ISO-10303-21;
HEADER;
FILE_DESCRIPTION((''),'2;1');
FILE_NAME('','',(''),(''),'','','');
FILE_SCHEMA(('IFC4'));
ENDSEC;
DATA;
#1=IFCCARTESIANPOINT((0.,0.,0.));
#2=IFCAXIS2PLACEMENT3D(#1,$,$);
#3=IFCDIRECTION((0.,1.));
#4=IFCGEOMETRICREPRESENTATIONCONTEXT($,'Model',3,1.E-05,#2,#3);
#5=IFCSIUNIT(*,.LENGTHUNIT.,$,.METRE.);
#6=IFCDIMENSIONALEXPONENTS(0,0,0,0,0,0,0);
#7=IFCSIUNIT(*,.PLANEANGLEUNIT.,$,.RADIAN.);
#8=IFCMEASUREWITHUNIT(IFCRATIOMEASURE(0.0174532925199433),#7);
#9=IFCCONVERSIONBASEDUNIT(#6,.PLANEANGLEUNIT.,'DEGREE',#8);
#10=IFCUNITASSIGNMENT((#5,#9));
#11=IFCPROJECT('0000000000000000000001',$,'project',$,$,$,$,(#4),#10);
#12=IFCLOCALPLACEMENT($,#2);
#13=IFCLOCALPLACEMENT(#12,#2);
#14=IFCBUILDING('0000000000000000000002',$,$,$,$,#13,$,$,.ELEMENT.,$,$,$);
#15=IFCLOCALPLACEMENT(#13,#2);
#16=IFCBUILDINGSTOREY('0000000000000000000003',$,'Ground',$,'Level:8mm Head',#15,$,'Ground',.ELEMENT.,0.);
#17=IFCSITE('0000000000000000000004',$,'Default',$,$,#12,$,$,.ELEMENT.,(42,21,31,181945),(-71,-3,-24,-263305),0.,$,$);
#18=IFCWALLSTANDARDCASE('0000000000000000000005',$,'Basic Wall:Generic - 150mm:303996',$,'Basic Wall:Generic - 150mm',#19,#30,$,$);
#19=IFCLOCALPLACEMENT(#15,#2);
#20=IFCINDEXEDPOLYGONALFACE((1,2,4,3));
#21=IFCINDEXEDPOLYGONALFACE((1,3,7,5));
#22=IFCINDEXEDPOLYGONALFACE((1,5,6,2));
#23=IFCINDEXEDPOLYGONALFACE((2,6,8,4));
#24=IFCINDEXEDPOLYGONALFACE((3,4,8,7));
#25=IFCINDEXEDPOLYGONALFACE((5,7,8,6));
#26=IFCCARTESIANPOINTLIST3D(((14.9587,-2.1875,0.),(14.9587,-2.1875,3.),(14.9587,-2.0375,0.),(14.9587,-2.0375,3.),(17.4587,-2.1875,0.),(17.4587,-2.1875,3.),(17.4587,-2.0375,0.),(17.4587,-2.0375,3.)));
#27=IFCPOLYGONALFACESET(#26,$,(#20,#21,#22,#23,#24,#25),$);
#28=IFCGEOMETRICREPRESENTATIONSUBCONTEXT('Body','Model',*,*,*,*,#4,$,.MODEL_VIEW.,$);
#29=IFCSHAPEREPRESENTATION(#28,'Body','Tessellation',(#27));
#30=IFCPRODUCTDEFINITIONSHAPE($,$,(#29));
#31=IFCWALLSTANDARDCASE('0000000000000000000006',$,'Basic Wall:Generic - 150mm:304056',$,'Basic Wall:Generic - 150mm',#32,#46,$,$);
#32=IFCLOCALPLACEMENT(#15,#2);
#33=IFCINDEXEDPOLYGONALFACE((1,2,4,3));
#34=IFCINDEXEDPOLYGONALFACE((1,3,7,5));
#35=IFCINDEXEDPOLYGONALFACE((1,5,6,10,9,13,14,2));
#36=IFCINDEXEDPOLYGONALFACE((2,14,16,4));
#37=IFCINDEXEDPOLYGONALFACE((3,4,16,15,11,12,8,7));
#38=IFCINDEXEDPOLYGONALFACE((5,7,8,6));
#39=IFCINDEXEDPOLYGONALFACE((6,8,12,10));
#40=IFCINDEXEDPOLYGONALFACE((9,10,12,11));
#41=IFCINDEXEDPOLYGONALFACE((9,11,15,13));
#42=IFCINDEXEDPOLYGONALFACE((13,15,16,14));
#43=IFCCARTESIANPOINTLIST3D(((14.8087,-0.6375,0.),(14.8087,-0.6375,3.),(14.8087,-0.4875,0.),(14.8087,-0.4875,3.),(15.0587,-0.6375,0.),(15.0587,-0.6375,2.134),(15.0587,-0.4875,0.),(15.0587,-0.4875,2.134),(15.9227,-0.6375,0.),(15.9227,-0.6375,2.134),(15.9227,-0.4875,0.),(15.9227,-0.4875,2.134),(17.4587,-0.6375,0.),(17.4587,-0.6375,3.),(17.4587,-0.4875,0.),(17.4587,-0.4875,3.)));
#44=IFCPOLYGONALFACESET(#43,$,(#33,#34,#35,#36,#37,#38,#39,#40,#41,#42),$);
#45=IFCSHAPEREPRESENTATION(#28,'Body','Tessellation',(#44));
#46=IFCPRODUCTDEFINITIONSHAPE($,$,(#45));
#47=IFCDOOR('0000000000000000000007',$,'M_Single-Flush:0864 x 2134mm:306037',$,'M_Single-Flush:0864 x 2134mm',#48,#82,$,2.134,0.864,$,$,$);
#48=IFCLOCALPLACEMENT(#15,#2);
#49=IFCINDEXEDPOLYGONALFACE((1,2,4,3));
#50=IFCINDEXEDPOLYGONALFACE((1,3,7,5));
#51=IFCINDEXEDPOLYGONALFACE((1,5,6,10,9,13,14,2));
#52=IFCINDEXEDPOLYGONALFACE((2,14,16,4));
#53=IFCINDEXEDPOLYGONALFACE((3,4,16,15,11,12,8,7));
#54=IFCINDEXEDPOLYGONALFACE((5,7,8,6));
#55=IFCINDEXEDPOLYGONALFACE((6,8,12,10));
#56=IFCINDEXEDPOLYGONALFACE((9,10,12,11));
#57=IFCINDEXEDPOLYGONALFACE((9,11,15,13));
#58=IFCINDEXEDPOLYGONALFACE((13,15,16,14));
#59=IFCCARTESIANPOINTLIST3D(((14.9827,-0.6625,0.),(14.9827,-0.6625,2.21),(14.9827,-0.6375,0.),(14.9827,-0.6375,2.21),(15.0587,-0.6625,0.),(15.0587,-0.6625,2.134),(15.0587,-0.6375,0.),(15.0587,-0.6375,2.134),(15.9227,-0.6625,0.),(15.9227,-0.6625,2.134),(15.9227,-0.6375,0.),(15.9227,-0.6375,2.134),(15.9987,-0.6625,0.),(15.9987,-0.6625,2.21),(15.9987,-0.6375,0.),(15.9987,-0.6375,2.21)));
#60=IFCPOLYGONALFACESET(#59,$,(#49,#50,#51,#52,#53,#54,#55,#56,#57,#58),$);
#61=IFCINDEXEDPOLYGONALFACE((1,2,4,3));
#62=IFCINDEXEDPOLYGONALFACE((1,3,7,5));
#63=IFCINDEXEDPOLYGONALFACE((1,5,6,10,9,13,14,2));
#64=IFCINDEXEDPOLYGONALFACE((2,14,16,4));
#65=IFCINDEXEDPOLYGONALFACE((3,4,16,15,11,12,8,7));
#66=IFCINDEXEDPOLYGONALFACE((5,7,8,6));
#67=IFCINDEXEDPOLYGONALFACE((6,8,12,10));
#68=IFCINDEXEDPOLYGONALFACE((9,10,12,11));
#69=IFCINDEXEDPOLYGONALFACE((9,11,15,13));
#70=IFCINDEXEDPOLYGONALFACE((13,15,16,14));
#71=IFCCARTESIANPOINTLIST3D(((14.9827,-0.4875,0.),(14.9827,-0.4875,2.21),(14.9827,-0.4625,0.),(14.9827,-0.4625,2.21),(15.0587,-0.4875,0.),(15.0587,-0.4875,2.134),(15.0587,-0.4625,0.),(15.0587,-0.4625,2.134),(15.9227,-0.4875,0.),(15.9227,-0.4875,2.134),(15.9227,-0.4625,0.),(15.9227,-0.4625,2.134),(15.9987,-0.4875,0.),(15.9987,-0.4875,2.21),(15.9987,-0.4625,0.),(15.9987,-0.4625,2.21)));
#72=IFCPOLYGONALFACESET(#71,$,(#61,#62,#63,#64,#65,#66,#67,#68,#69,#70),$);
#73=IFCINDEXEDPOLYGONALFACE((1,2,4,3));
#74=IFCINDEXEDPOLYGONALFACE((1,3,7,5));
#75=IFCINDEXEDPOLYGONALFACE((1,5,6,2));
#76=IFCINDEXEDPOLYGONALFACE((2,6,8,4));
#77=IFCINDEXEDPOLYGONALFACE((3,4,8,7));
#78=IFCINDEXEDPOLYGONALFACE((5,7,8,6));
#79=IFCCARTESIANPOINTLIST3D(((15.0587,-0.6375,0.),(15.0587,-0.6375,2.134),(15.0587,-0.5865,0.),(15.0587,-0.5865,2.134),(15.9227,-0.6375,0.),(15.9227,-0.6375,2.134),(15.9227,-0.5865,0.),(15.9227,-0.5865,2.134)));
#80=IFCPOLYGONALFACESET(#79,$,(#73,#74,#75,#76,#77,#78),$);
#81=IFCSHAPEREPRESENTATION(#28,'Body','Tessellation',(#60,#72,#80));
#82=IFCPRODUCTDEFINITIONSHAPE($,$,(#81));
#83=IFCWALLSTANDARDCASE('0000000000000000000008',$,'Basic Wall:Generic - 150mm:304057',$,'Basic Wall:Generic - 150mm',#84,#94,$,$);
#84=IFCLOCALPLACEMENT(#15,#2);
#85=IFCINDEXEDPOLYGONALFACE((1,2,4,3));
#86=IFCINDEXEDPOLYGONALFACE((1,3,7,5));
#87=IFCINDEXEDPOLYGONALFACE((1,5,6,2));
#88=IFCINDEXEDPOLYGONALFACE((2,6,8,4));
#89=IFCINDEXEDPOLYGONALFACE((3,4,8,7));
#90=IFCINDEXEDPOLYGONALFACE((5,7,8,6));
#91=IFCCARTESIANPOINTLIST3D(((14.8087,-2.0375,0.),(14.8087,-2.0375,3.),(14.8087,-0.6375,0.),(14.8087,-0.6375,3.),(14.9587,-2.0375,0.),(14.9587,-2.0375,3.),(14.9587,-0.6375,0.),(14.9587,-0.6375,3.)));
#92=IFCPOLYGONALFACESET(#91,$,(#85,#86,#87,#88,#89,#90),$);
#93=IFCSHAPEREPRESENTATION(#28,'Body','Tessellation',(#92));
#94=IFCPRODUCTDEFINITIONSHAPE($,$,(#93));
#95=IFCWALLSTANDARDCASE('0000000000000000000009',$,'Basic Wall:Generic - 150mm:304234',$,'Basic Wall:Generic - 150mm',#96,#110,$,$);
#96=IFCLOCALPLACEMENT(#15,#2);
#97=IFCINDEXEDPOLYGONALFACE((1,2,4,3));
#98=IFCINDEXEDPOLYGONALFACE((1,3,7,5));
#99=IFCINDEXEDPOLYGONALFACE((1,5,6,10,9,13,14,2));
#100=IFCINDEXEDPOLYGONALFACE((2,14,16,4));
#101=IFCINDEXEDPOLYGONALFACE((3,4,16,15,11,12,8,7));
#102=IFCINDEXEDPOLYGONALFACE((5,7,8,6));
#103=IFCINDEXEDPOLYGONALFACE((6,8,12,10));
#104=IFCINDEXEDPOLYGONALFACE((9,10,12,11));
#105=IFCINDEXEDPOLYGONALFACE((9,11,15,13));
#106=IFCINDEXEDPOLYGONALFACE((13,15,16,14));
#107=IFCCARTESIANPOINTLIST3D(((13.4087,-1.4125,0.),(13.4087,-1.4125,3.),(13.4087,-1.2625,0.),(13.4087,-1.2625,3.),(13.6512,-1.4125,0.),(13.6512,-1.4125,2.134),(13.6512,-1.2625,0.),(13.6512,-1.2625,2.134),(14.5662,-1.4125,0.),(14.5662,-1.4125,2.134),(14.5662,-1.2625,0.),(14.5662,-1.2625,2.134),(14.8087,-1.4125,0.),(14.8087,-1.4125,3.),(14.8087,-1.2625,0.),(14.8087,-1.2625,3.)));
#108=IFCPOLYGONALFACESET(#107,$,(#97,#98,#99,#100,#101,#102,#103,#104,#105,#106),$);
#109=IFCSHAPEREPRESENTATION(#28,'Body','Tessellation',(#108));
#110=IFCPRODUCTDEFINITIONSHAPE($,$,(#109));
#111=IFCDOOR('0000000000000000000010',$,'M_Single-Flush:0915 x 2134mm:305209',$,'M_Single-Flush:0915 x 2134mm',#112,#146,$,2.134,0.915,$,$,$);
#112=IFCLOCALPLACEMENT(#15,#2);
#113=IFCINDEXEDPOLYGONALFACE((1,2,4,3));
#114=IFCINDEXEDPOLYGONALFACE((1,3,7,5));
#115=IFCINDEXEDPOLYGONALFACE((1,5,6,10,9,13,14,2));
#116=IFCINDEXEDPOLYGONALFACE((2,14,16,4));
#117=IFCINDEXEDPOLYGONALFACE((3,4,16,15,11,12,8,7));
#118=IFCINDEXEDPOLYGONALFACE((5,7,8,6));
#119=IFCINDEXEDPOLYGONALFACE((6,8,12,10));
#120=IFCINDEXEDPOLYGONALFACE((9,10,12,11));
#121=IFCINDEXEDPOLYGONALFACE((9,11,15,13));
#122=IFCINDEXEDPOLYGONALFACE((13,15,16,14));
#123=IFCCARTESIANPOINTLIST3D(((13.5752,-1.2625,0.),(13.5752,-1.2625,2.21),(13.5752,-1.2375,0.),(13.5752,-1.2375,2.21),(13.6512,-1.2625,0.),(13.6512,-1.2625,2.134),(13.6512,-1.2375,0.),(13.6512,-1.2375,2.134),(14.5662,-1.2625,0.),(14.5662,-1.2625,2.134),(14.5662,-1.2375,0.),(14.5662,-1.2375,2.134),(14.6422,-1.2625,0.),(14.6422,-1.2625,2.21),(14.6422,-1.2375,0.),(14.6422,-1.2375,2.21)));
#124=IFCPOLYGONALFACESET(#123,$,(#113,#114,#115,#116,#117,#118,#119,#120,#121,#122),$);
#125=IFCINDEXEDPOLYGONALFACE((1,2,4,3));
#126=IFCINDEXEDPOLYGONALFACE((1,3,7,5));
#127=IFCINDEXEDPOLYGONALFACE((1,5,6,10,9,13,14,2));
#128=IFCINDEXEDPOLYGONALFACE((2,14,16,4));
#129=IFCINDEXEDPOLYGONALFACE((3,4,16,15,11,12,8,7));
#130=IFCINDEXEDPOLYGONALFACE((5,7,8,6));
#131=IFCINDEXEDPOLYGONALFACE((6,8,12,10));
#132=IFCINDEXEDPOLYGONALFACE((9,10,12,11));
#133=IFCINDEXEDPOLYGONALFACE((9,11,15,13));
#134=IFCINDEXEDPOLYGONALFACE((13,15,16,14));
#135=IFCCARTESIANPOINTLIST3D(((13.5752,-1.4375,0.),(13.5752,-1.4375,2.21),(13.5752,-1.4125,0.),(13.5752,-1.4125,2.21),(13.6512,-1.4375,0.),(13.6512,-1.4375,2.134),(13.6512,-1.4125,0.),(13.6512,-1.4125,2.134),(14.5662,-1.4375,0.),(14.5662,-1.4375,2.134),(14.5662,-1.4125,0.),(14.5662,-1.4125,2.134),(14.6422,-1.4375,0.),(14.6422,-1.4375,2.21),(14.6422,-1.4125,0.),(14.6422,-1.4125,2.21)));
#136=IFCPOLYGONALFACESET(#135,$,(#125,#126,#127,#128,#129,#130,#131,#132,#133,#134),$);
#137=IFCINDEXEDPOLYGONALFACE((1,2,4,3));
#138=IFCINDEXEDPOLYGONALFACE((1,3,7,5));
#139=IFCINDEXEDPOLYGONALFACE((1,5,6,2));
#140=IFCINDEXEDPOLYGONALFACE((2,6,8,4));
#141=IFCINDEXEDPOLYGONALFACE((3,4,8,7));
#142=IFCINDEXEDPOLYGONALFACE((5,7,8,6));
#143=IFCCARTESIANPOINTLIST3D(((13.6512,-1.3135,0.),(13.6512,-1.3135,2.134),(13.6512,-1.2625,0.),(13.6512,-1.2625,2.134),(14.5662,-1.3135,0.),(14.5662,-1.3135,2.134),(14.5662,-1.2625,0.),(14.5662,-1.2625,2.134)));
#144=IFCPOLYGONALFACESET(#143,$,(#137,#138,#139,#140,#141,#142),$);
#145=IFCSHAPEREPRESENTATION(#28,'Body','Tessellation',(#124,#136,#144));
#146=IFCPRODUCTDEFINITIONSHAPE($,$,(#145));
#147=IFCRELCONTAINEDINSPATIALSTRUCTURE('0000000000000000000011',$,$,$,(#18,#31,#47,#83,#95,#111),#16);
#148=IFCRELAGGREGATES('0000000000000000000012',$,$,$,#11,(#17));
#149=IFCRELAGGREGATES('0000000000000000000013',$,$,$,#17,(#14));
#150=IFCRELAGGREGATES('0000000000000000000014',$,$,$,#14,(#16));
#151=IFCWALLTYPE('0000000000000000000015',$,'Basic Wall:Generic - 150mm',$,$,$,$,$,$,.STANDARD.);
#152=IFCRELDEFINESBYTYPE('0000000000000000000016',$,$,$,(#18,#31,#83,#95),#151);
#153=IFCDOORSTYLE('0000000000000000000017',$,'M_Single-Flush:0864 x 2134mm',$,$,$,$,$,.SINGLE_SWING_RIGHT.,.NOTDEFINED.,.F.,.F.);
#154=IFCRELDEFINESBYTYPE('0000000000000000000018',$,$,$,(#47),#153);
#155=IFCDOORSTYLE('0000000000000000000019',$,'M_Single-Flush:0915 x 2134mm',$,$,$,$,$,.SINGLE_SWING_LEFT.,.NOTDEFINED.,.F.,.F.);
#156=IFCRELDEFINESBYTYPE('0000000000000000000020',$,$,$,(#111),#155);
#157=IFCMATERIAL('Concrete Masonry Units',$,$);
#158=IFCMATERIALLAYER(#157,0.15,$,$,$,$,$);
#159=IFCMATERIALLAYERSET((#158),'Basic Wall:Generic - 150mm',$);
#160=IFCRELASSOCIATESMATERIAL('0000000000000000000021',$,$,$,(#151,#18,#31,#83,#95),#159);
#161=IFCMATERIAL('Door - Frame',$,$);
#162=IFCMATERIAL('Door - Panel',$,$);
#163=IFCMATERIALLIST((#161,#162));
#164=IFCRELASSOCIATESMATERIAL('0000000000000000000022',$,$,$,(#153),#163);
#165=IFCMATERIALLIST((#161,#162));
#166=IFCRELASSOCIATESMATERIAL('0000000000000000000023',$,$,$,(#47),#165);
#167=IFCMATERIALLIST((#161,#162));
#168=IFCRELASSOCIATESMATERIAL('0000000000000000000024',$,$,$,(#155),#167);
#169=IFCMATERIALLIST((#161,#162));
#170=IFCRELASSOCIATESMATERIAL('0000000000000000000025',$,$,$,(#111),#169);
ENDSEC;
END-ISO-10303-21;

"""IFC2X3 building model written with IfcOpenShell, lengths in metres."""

from ifc_helpers import new_model, entity, si_unit, converted_unit, direction, frame, frame_2d, origin, place, context, subcontext, project, spatial, polyline, rectangle, outline, extrude, source, transform, mapped, material, material_list, layer, layer_set, layer_usage, type_object, type_shapes, element, fill, save


model = new_model("IFC2X3")

# Units and contexts
model_context = context("Model", 3, precision=1e-05, world=origin(), true_north=direction((0.0, 1.0)))
body_context = subcontext(model_context, "Body", "Model", "MODEL_VIEW")
ifc_project = project(units=[si_unit("LENGTHUNIT", "METRE"), converted_unit("PLANEANGLEUNIT", "DEGREE", entity("IfcRatioMeasure", 0.0174532925199433), si_unit("PLANEANGLEUNIT", "RADIAN"), dimensions=[0, 0, 0, 0, 0, 0, 0])], contexts=[model_context])

# Site, building, storey
site_placement = place(None, origin())
site = spatial("IfcSite", under=ifc_project, at=site_placement, Name="Default", CompositionType="ELEMENT", RefLatitude=(42, 21, 31, 181945), RefLongitude=(-71, -3, -24, -263305), RefElevation=0.0)
building_placement = place(site_placement, origin())
building = spatial("IfcBuilding", under=site, at=building_placement, CompositionType="ELEMENT")
storey_placement = place(building_placement, origin())
storey = spatial("IfcBuildingStorey", under=building, at=storey_placement, Name="Ground", ObjectType="Level:8mm Head", LongName="Ground", CompositionType="ELEMENT", Elevation=0.0)

# Wall
ifc_material_1 = material(Name="Concrete Masonry Units")
ifc_layer = layer(ifc_material_1, 0.15)
ifc_layer_set = layer_set([ifc_layer], Name="Basic Wall:Generic - 150mm")
ifc_layer_usage_1 = layer_usage(ifc_layer_set, "AXIS2", "POSITIVE", -0.075)
wall_type = type_object("IfcWallType", Name="Basic Wall:Generic - 150mm", PredefinedType="STANDARD", material=ifc_layer_set)
wall_1_placement = place(storey_placement, frame((14.9587, -2.1125, 0.0)))
element("IfcWallStandardCase", 1, at=wall_1_placement, inside=storey, type_object=wall_type, material=ifc_layer_usage_1, Name="Basic Wall:Generic - 150mm:303996", ObjectType="Basic Wall:Generic - 150mm", context=body_context, shape_type="SweptSolid", body=[
    extrude(rectangle(XDim=2.5, YDim=0.15, at=frame_2d((1.25, 0.0), x_axis=(-1.0, 0.0))), origin(), (0.0, 0.0, 1.0), 3.0),
])

# Wall, opening, door
ifc_layer_usage_2 = layer_usage(ifc_layer_set, "AXIS2", "POSITIVE", -0.075)
wall_2_placement = place(storey_placement, frame((17.4587, -0.5625, 0.0), z_axis=(0.0, 0.0, 1.0), x_axis=(-1.0, 0.0, 0.0)))
wall_2 = element("IfcWallStandardCase", 2, at=wall_2_placement, inside=storey, type_object=wall_type, material=ifc_layer_usage_2, Name="Basic Wall:Generic - 150mm:304056", ObjectType="Basic Wall:Generic - 150mm", context=body_context, shape_type="SweptSolid", body=[
    extrude(rectangle(XDim=2.65, YDim=0.15, at=frame_2d((1.325, 0.0), x_axis=(-1.0, 0.0))), origin(), (0.0, 0.0, 1.0), 3.0),
])
opening_1_placement = place(wall_2_placement, frame((1.536, -0.075, 0.0)))
opening_1 = element("IfcOpeningElement", 3, at=opening_1_placement, cuts=wall_2, ObjectType="Opening", context=body_context, shape_type="SweptSolid", body=[
    extrude(rectangle(XDim=0.864, YDim=2.134, at=frame_2d((1.067, 0.432), x_axis=(0.0, 1.0))), frame((0.0, 0.0, 0.0), z_axis=(0.0, 1.0, 0.0), x_axis=(0.0, 0.0, 1.0)), (0.0, 0.0, 1.0), 0.15),
])
ifc_material_2 = material(Name="Door - Frame")
ifc_material_3 = material(Name="Door - Panel")
ifc_material_list_1 = material_list([ifc_material_2, ifc_material_3])
ifc_material_list_2 = material_list([ifc_material_2, ifc_material_3])
door_style_1 = type_object("IfcDoorStyle", Name="M_Single-Flush:0864 x 2134mm", ConstructionType="NOTDEFINED", OperationType="SINGLE_SWING_RIGHT", ParameterTakesPrecedence=False, Sizeable=False, material=ifc_material_list_2)
shared_shape_1 = source(origin(), body_context, "Body", "SweptSolid", [
    extrude(outline(polyline([(-0.508, -1.124), (0.508, -1.124), (0.508, 1.086), (0.432, 1.086), (0.432, -1.048), (-0.432, -1.048), (-0.432, 1.086), (-0.508, 1.086), (-0.508, -1.124)])), frame((0.432, 0.15, 1.086), z_axis=(0.0, 1.0, 0.0), x_axis=(1.0, 0.0, 0.0)), (0.0, 0.0, 1.0), 0.025),
    extrude(outline(polyline([(-1.124, -0.508), (1.086, -0.508), (1.086, -0.432), (-1.048, -0.432), (-1.048, 0.432), (1.086, 0.432), (1.086, 0.508), (-1.124, 0.508), (-1.124, -0.508)])), frame((0.432, -0.025, 1.086), z_axis=(0.0, 1.0, 0.0), x_axis=(0.0, 0.0, -1.0)), (0.0, 0.0, 1.0), 0.025),
    extrude(rectangle(XDim=0.051, YDim=0.864, at=frame_2d((0.0, 0.0), x_axis=(1.0, 0.0))), frame((0.432, 0.1245, 0.0), z_axis=(0.0, 0.0, 1.0), x_axis=(0.0, 1.0, 0.0)), (0.0, 0.0, 1.0), 2.134),
])
type_shapes(door_style_1, [shared_shape_1])
door_1_placement = place(opening_1_placement, origin())
door_1 = element("IfcDoor", 4, at=door_1_placement, inside=storey, type_object=door_style_1, material=ifc_material_list_1, Name="M_Single-Flush:0864 x 2134mm:306037", ObjectType="M_Single-Flush:0864 x 2134mm", OverallHeight=2.134, OverallWidth=0.864, context=body_context, shape_type="MappedRepresentation", body=[
    mapped(shared_shape_1, transform((0.0, 0.0, 0.0), scale=1.0)),
])
fill(opening_1, door_1)

# Wall
ifc_layer_usage_3 = layer_usage(ifc_layer_set, "AXIS2", "NEGATIVE", 0.075)
wall_3_placement = place(storey_placement, frame((14.8837, -0.6375, 0.0), z_axis=(0.0, 0.0, 1.0), x_axis=(0.0, -1.0, 0.0)))
element("IfcWallStandardCase", 5, at=wall_3_placement, inside=storey, type_object=wall_type, material=ifc_layer_usage_3, Name="Basic Wall:Generic - 150mm:304057", ObjectType="Basic Wall:Generic - 150mm", context=body_context, shape_type="SweptSolid", body=[
    extrude(rectangle(XDim=1.4, YDim=0.15, at=frame_2d((0.7, 0.0), x_axis=(-1.0, 0.0))), origin(), (0.0, 0.0, 1.0), 3.0),
])

# Wall, opening, door
ifc_layer_usage_4 = layer_usage(ifc_layer_set, "AXIS2", "NEGATIVE", 0.075)
wall_4_placement = place(storey_placement, frame((14.8087, -1.3375, 0.0), z_axis=(0.0, 0.0, 1.0), x_axis=(-1.0, 0.0, 0.0)))
wall_4 = element("IfcWallStandardCase", 6, at=wall_4_placement, inside=storey, type_object=wall_type, material=ifc_layer_usage_4, Name="Basic Wall:Generic - 150mm:304234", ObjectType="Basic Wall:Generic - 150mm", context=body_context, shape_type="SweptSolid", body=[
    extrude(rectangle(XDim=1.4, YDim=0.15, at=frame_2d((0.7, 0.0), x_axis=(-1.0, 0.0))), origin(), (0.0, 0.0, 1.0), 3.0),
])
opening_2_placement = place(wall_4_placement, frame((1.1575, 0.075, 0.0)))
opening_2 = element("IfcOpeningElement", 7, at=opening_2_placement, cuts=wall_4, ObjectType="Opening", context=body_context, shape_type="SweptSolid", body=[
    extrude(rectangle(XDim=0.915, YDim=2.134, at=frame_2d((1.067, 0.4575), x_axis=(0.0, -1.0))), frame((0.0, 0.0, 0.0), z_axis=(0.0, -1.0, 0.0), x_axis=(0.0, 0.0, 1.0)), (0.0, 0.0, 1.0), 0.15),
])
ifc_material_list_3 = material_list([ifc_material_2, ifc_material_3])
ifc_material_list_4 = material_list([ifc_material_2, ifc_material_3])
door_style_2 = type_object("IfcDoorStyle", Name="M_Single-Flush:0915 x 2134mm", ConstructionType="NOTDEFINED", OperationType="SINGLE_SWING_LEFT", ParameterTakesPrecedence=False, Sizeable=False, material=ifc_material_list_4)
shared_shape_2 = source(origin(), body_context, "Body", "SweptSolid", [
    extrude(outline(polyline([(-0.5335, -1.124), (0.5335, -1.124), (0.5335, 1.086), (0.4575, 1.086), (0.4575, -1.048), (-0.4575, -1.048), (-0.4575, 1.086), (-0.5335, 1.086), (-0.5335, -1.124)])), frame((0.4575, 0.175, 1.086), z_axis=(0.0, -1.0, 0.0), x_axis=(-1.0, 0.0, 0.0)), (0.0, 0.0, 1.0), 0.025),
    extrude(outline(polyline([(-1.124, -0.5335), (1.086, -0.5335), (1.086, -0.4575), (-1.048, -0.4575), (-1.048, 0.4575), (1.086, 0.4575), (1.086, 0.5335), (-1.124, 0.5335), (-1.124, -0.5335)])), frame((0.4575, 0.0, 1.086), z_axis=(0.0, -1.0, 0.0), x_axis=(0.0, 0.0, -1.0)), (0.0, 0.0, 1.0), 0.025),
    extrude(rectangle(XDim=0.915, YDim=0.051, at=frame_2d((0.0, 0.0), x_axis=(1.0, 0.0))), frame((0.4575, 0.1245, 0.0)), (0.0, 0.0, 1.0), 2.134),
])
type_shapes(door_style_2, [shared_shape_2])
door_2_placement = place(opening_2_placement, frame((0.0, 0.0, 0.0), z_axis=(0.0, 0.0, 1.0), x_axis=(-1.0, 0.0, 0.0)))
door_2 = element("IfcDoor", 8, at=door_2_placement, inside=storey, type_object=door_style_2, material=ifc_material_list_3, Name="M_Single-Flush:0915 x 2134mm:305209", ObjectType="M_Single-Flush:0915 x 2134mm", OverallHeight=2.134, OverallWidth=0.915, context=body_context, shape_type="MappedRepresentation", body=[
    mapped(shared_shape_2, transform((0.0, 0.0, 0.0), scale=1.0)),
])
fill(opening_2, door_2)

save(model, "model.ifc")
